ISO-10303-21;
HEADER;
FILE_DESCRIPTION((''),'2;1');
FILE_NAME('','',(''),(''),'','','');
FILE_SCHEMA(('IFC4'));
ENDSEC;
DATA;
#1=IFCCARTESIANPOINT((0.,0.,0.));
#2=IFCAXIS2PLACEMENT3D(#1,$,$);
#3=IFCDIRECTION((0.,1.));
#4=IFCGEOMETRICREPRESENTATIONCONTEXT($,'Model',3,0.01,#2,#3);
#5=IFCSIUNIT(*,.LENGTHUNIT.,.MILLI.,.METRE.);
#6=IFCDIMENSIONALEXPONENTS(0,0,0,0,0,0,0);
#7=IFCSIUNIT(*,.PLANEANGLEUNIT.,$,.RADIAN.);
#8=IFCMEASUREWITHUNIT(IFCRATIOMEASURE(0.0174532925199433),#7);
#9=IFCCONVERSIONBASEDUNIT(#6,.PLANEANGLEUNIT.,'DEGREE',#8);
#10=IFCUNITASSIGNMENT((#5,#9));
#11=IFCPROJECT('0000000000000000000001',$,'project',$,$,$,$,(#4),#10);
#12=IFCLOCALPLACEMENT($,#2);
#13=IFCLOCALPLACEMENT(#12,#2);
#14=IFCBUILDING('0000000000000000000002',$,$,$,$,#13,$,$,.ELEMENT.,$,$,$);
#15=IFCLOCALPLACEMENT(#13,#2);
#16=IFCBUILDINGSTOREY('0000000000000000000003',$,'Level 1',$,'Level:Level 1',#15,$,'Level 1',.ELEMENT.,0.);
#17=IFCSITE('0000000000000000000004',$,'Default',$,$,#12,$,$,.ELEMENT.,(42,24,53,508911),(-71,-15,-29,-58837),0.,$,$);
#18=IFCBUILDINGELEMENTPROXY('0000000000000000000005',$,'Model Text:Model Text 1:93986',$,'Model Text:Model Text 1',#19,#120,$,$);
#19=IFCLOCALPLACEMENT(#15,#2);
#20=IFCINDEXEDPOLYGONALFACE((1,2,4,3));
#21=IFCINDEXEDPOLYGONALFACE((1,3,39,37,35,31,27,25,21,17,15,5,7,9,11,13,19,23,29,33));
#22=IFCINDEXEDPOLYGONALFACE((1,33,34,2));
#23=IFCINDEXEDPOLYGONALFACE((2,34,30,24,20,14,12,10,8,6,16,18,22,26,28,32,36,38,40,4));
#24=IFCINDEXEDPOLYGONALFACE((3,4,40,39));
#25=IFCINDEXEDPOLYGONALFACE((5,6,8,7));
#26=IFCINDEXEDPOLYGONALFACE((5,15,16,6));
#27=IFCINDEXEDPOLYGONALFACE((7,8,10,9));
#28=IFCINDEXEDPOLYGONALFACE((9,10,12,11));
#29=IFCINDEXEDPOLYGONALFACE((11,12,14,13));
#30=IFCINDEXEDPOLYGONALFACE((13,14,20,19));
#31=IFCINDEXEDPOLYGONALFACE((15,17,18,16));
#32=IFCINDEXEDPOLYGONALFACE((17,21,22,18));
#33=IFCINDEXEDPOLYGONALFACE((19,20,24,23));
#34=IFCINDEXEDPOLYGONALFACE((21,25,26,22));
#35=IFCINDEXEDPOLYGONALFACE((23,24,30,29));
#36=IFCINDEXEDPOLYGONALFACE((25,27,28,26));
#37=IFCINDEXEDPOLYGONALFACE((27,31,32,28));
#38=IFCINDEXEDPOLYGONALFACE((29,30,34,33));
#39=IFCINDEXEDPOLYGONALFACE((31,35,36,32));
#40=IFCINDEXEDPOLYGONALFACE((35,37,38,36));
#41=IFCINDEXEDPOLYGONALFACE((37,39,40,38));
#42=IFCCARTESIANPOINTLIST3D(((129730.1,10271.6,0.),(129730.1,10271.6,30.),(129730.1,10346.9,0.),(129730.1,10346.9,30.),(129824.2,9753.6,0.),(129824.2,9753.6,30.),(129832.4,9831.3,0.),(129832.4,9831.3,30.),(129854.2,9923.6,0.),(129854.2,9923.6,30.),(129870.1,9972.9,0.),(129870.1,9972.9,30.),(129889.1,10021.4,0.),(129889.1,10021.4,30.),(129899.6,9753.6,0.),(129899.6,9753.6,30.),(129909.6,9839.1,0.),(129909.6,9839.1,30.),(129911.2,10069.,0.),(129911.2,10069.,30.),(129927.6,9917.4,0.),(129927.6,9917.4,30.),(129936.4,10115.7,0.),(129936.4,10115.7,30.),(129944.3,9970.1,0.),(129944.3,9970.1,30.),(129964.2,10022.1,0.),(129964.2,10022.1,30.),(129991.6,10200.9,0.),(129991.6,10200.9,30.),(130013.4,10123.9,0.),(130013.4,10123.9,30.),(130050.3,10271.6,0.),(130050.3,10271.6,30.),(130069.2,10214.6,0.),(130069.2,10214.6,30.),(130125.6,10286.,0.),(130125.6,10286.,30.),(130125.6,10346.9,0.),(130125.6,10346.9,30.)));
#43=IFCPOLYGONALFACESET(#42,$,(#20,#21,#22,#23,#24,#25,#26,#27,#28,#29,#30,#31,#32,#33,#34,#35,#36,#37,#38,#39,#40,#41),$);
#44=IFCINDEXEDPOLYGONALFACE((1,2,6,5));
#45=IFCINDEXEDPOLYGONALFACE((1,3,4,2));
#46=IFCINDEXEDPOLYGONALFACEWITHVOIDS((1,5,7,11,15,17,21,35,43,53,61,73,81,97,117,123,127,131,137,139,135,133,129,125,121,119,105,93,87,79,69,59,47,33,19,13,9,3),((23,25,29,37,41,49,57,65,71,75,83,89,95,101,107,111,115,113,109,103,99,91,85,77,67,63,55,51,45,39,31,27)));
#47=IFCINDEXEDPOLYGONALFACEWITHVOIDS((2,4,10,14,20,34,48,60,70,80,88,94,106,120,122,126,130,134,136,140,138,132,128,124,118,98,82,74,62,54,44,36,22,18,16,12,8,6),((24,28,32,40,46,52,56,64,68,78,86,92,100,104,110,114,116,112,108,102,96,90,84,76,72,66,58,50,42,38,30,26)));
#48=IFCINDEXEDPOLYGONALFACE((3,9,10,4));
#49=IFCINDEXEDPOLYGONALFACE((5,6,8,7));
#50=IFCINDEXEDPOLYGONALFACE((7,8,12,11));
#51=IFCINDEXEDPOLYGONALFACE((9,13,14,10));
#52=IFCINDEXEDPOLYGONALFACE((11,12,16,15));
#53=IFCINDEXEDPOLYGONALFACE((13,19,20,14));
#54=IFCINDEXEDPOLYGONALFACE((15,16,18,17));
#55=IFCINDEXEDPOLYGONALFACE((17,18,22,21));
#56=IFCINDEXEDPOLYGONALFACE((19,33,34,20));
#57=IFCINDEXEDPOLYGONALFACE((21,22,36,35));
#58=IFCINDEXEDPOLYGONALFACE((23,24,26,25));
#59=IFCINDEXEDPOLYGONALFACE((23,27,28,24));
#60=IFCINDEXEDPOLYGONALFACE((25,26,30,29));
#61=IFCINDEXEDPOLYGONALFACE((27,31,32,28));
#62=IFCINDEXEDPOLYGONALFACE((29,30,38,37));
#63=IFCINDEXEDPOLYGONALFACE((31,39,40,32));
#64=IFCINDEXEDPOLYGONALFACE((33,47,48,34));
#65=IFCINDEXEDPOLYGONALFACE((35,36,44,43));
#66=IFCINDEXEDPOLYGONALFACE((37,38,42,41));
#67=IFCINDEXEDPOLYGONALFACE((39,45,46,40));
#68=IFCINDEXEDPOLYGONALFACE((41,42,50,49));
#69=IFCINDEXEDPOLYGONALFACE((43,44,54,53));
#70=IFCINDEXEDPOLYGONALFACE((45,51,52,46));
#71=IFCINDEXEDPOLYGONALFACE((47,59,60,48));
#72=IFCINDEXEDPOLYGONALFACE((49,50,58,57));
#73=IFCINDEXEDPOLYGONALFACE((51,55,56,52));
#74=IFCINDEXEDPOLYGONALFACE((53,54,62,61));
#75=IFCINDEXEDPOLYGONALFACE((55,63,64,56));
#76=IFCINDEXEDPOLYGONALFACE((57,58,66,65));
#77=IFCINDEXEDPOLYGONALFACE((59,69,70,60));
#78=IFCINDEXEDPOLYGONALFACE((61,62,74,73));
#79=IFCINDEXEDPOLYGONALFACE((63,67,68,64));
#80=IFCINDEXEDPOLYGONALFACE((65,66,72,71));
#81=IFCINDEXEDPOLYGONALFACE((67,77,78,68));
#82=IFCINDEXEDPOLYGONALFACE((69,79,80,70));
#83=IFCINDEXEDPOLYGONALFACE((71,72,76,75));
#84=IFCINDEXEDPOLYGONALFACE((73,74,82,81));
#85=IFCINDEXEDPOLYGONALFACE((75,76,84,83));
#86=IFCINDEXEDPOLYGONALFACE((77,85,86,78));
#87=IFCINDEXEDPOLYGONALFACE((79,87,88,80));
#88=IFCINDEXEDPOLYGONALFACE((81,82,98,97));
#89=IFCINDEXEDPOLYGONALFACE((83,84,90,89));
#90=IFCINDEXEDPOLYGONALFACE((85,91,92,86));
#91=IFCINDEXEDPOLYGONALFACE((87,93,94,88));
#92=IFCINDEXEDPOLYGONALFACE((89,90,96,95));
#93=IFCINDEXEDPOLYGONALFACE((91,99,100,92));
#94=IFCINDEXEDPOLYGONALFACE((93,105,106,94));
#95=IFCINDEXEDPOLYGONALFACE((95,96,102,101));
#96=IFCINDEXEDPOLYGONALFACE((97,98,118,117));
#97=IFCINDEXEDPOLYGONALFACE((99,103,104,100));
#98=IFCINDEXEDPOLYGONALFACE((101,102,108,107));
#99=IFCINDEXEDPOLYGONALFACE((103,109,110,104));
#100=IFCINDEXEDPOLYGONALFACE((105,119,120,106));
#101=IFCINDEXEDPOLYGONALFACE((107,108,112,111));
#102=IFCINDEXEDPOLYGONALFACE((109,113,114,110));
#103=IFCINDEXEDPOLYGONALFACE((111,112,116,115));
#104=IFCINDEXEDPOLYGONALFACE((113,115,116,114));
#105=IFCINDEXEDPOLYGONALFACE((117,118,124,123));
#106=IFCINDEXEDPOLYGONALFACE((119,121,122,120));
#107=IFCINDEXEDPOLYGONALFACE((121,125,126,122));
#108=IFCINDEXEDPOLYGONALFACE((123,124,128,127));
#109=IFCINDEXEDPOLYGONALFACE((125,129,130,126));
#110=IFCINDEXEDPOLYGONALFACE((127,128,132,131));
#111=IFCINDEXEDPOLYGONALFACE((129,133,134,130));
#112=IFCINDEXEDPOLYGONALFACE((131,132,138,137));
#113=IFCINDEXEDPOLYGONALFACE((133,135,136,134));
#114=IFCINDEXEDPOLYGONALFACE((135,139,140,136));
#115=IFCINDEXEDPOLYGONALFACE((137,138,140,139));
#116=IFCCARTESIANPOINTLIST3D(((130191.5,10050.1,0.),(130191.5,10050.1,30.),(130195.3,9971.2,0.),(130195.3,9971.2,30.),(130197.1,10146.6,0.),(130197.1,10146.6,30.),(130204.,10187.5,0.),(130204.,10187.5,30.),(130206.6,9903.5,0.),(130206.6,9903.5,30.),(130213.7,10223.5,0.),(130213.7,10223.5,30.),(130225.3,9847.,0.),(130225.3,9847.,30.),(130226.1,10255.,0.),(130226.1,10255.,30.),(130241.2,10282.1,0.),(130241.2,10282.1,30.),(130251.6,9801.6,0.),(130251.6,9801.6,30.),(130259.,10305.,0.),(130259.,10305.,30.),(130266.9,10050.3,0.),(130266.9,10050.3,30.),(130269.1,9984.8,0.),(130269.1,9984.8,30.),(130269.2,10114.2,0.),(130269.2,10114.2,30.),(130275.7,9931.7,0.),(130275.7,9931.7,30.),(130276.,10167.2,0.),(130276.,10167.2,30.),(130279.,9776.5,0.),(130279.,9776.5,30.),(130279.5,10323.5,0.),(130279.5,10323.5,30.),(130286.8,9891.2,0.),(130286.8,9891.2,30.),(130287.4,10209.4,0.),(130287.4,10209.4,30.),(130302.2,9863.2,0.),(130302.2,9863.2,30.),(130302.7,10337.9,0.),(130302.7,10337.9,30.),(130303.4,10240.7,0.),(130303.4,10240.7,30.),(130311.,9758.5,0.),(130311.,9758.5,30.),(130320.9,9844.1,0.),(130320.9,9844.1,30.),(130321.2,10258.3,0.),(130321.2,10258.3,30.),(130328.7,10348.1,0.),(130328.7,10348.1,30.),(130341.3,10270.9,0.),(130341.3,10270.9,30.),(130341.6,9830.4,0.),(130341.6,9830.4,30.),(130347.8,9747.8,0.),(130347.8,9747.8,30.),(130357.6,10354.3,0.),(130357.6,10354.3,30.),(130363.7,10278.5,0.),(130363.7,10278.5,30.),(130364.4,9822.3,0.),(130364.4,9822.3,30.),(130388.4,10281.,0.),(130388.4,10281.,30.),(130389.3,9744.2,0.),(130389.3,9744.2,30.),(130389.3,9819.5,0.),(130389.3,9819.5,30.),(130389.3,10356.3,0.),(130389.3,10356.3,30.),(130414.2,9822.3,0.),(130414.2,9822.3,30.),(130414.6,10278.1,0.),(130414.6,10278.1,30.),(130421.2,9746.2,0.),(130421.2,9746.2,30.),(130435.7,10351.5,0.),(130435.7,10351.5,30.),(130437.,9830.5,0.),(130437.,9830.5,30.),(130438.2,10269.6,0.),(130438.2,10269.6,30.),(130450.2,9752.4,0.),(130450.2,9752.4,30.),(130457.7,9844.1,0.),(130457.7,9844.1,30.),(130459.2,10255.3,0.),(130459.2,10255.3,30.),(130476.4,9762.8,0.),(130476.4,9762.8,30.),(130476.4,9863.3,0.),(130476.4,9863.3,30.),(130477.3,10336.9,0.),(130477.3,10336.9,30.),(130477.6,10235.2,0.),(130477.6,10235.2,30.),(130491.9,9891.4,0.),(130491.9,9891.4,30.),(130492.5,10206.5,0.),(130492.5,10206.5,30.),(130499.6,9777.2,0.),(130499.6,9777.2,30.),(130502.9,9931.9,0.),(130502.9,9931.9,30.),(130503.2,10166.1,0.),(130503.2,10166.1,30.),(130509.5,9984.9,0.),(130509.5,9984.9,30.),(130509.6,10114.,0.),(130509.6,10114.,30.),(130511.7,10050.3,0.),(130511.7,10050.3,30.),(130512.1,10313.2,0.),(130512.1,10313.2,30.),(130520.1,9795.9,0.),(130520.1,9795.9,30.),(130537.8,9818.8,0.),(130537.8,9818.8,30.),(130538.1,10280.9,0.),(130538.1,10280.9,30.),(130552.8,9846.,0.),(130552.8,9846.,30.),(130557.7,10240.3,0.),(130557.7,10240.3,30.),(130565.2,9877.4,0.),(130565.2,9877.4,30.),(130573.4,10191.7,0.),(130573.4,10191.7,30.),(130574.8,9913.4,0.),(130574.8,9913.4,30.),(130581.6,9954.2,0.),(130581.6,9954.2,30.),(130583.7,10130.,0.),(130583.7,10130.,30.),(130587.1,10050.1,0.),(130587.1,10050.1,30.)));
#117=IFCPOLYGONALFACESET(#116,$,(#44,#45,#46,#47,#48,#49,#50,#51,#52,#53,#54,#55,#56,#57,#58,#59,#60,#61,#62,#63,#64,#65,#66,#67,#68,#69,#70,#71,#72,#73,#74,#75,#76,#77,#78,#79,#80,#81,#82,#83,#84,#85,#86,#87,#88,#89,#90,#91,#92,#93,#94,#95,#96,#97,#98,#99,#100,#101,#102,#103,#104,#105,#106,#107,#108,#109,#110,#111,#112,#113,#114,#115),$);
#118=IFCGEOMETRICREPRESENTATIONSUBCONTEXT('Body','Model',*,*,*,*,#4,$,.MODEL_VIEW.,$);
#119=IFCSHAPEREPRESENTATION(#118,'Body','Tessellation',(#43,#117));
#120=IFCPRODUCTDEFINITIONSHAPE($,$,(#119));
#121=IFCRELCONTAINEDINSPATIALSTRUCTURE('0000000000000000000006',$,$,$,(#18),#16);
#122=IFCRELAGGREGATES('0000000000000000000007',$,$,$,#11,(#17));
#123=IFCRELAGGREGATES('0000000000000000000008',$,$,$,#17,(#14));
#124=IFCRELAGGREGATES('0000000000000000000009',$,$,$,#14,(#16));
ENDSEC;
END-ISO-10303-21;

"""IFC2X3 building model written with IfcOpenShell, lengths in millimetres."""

from ifc_helpers import new_model, entity, si_unit, converted_unit, direction, frame, origin, place, context, subcontext, project, spatial, polyline, outline, extrude, element, save


model = new_model("IFC2X3")

# Units and contexts
model_context = context("Model", 3, precision=0.01, world=origin(), true_north=direction((0.0, 1.0)))
body_context = subcontext(model_context, "Body", "Model", "MODEL_VIEW")
ifc_project = project(units=[si_unit("LENGTHUNIT", "METRE", prefix="MILLI"), converted_unit("PLANEANGLEUNIT", "DEGREE", entity("IfcRatioMeasure", 0.0174532925199433), si_unit("PLANEANGLEUNIT", "RADIAN"), dimensions=[0, 0, 0, 0, 0, 0, 0])], contexts=[model_context])

# Site, building, storey
site_placement = place(None, origin())
site = spatial("IfcSite", under=ifc_project, at=site_placement, Name="Default", CompositionType="ELEMENT", RefLatitude=(42, 24, 53, 508911), RefLongitude=(-71, -15, -29, -58837), RefElevation=0.0)
building_placement = place(site_placement, origin())
building = spatial("IfcBuilding", under=site, at=building_placement, CompositionType="ELEMENT")
storey_placement = place(building_placement, origin())
storey = spatial("IfcBuildingStorey", under=building, at=storey_placement, Name="Level 1", ObjectType="Level:Level 1", LongName="Level 1", CompositionType="ELEMENT", Elevation=0.0)

# Building element proxy
proxy_1_placement = place(storey_placement, origin())
element("IfcBuildingElementProxy", 1, at=proxy_1_placement, inside=storey, Name="Model Text:Model Text 1:93986", ObjectType="Model Text:Model Text 1", context=body_context, shape_type="SweptSolid", body=[
    extrude(outline(polyline([(-199.9, -209.0), (-199.9, -284.3), (195.7, -284.3), (195.7, -223.4), (139.3, -152.0), (83.5, -61.3), (34.2, 40.5), (14.4, 92.5), (-2.4, 145.2), (-20.3, 223.5), (-30.3, 309.0), (-105.7, 309.0), (-97.5, 231.3), (-75.7, 139.0), (-59.9, 89.7), (-40.9, 41.2), (-18.8, -6.4), (6.4, -53.1), (61.7, -138.3), (120.3, -209.0), (-199.9, -209.0)])), frame((129929.9, 10062.6, 0.0), z_axis=(0.0, 0.0, -1.0), x_axis=(1.0, 0.0, 0.0)), (0.0, 0.0, -1.0), 30.0),
    extrude(outline(polyline([(-10.6, -198.7), (68.3, -198.7), (136.5, -190.7), (193.9, -174.7), (240.5, -150.6), (266.9, -124.4), (286.3, -93.2), (298.8, -57.0), (304.3, -15.7), (303.8, 16.2), (299.0, 45.5), (289.9, 72.1), (276.6, 96.0), (258.9, 117.3), (236.9, 136.2), (210.4, 152.5), (179.6, 166.3), (144.1, 177.6), (103.7, 186.3), (8.2, 196.4), (-71.8, 196.7), (-134.0, 189.4), (-183.3, 176.1), (-224.7, 158.4), (-258.2, 133.9), (-283.5, 100.3), (-300.1, 59.5), (-307.1, 13.4), (-306.6, -18.4), (-301.8, -47.5), (-292.8, -74.0), (-279.6, -97.9), (-262.0, -119.2), (-240.0, -138.1), (-213.6, -154.5), (-182.8, -168.4), (-147.3, -179.8), (-106.7, -188.6), (-10.6, -198.7)]), holes=[polyline([(-7.2, -123.5), (-71.0, -118.2), (-123.6, -108.8), (-165.2, -95.4), (-195.7, -78.0), (-212.4, -59.4), (-224.1, -38.7), (-230.6, -15.9), (-231.9, 8.9), (-227.8, 35.0), (-218.1, 58.1), (-202.8, 78.4), (-182.0, 95.8), (-152.6, 109.4), (-111.7, 118.1), (-59.4, 122.0), (4.4, 121.1), (69.6, 115.8), (122.2, 106.7), (162.2, 93.7), (189.5, 77.0), (207.7, 57.4), (220.4, 36.0), (227.5, 12.8), (229.1, -12.1), (225.2, -36.8), (215.9, -59.2), (201.3, -79.3), (181.4, -97.1), (152.6, -111.2), (111.6, -120.3), (58.3, -124.4), (-7.2, -123.5)])]), frame((130390.6, 10048.9, 0.0), z_axis=(0.0, 0.0, 1.0), x_axis=(0.047515, -0.998871, 0.0)), (0.0, 0.0, 1.0), 30.0),
])

save(model, "model.ifc")
